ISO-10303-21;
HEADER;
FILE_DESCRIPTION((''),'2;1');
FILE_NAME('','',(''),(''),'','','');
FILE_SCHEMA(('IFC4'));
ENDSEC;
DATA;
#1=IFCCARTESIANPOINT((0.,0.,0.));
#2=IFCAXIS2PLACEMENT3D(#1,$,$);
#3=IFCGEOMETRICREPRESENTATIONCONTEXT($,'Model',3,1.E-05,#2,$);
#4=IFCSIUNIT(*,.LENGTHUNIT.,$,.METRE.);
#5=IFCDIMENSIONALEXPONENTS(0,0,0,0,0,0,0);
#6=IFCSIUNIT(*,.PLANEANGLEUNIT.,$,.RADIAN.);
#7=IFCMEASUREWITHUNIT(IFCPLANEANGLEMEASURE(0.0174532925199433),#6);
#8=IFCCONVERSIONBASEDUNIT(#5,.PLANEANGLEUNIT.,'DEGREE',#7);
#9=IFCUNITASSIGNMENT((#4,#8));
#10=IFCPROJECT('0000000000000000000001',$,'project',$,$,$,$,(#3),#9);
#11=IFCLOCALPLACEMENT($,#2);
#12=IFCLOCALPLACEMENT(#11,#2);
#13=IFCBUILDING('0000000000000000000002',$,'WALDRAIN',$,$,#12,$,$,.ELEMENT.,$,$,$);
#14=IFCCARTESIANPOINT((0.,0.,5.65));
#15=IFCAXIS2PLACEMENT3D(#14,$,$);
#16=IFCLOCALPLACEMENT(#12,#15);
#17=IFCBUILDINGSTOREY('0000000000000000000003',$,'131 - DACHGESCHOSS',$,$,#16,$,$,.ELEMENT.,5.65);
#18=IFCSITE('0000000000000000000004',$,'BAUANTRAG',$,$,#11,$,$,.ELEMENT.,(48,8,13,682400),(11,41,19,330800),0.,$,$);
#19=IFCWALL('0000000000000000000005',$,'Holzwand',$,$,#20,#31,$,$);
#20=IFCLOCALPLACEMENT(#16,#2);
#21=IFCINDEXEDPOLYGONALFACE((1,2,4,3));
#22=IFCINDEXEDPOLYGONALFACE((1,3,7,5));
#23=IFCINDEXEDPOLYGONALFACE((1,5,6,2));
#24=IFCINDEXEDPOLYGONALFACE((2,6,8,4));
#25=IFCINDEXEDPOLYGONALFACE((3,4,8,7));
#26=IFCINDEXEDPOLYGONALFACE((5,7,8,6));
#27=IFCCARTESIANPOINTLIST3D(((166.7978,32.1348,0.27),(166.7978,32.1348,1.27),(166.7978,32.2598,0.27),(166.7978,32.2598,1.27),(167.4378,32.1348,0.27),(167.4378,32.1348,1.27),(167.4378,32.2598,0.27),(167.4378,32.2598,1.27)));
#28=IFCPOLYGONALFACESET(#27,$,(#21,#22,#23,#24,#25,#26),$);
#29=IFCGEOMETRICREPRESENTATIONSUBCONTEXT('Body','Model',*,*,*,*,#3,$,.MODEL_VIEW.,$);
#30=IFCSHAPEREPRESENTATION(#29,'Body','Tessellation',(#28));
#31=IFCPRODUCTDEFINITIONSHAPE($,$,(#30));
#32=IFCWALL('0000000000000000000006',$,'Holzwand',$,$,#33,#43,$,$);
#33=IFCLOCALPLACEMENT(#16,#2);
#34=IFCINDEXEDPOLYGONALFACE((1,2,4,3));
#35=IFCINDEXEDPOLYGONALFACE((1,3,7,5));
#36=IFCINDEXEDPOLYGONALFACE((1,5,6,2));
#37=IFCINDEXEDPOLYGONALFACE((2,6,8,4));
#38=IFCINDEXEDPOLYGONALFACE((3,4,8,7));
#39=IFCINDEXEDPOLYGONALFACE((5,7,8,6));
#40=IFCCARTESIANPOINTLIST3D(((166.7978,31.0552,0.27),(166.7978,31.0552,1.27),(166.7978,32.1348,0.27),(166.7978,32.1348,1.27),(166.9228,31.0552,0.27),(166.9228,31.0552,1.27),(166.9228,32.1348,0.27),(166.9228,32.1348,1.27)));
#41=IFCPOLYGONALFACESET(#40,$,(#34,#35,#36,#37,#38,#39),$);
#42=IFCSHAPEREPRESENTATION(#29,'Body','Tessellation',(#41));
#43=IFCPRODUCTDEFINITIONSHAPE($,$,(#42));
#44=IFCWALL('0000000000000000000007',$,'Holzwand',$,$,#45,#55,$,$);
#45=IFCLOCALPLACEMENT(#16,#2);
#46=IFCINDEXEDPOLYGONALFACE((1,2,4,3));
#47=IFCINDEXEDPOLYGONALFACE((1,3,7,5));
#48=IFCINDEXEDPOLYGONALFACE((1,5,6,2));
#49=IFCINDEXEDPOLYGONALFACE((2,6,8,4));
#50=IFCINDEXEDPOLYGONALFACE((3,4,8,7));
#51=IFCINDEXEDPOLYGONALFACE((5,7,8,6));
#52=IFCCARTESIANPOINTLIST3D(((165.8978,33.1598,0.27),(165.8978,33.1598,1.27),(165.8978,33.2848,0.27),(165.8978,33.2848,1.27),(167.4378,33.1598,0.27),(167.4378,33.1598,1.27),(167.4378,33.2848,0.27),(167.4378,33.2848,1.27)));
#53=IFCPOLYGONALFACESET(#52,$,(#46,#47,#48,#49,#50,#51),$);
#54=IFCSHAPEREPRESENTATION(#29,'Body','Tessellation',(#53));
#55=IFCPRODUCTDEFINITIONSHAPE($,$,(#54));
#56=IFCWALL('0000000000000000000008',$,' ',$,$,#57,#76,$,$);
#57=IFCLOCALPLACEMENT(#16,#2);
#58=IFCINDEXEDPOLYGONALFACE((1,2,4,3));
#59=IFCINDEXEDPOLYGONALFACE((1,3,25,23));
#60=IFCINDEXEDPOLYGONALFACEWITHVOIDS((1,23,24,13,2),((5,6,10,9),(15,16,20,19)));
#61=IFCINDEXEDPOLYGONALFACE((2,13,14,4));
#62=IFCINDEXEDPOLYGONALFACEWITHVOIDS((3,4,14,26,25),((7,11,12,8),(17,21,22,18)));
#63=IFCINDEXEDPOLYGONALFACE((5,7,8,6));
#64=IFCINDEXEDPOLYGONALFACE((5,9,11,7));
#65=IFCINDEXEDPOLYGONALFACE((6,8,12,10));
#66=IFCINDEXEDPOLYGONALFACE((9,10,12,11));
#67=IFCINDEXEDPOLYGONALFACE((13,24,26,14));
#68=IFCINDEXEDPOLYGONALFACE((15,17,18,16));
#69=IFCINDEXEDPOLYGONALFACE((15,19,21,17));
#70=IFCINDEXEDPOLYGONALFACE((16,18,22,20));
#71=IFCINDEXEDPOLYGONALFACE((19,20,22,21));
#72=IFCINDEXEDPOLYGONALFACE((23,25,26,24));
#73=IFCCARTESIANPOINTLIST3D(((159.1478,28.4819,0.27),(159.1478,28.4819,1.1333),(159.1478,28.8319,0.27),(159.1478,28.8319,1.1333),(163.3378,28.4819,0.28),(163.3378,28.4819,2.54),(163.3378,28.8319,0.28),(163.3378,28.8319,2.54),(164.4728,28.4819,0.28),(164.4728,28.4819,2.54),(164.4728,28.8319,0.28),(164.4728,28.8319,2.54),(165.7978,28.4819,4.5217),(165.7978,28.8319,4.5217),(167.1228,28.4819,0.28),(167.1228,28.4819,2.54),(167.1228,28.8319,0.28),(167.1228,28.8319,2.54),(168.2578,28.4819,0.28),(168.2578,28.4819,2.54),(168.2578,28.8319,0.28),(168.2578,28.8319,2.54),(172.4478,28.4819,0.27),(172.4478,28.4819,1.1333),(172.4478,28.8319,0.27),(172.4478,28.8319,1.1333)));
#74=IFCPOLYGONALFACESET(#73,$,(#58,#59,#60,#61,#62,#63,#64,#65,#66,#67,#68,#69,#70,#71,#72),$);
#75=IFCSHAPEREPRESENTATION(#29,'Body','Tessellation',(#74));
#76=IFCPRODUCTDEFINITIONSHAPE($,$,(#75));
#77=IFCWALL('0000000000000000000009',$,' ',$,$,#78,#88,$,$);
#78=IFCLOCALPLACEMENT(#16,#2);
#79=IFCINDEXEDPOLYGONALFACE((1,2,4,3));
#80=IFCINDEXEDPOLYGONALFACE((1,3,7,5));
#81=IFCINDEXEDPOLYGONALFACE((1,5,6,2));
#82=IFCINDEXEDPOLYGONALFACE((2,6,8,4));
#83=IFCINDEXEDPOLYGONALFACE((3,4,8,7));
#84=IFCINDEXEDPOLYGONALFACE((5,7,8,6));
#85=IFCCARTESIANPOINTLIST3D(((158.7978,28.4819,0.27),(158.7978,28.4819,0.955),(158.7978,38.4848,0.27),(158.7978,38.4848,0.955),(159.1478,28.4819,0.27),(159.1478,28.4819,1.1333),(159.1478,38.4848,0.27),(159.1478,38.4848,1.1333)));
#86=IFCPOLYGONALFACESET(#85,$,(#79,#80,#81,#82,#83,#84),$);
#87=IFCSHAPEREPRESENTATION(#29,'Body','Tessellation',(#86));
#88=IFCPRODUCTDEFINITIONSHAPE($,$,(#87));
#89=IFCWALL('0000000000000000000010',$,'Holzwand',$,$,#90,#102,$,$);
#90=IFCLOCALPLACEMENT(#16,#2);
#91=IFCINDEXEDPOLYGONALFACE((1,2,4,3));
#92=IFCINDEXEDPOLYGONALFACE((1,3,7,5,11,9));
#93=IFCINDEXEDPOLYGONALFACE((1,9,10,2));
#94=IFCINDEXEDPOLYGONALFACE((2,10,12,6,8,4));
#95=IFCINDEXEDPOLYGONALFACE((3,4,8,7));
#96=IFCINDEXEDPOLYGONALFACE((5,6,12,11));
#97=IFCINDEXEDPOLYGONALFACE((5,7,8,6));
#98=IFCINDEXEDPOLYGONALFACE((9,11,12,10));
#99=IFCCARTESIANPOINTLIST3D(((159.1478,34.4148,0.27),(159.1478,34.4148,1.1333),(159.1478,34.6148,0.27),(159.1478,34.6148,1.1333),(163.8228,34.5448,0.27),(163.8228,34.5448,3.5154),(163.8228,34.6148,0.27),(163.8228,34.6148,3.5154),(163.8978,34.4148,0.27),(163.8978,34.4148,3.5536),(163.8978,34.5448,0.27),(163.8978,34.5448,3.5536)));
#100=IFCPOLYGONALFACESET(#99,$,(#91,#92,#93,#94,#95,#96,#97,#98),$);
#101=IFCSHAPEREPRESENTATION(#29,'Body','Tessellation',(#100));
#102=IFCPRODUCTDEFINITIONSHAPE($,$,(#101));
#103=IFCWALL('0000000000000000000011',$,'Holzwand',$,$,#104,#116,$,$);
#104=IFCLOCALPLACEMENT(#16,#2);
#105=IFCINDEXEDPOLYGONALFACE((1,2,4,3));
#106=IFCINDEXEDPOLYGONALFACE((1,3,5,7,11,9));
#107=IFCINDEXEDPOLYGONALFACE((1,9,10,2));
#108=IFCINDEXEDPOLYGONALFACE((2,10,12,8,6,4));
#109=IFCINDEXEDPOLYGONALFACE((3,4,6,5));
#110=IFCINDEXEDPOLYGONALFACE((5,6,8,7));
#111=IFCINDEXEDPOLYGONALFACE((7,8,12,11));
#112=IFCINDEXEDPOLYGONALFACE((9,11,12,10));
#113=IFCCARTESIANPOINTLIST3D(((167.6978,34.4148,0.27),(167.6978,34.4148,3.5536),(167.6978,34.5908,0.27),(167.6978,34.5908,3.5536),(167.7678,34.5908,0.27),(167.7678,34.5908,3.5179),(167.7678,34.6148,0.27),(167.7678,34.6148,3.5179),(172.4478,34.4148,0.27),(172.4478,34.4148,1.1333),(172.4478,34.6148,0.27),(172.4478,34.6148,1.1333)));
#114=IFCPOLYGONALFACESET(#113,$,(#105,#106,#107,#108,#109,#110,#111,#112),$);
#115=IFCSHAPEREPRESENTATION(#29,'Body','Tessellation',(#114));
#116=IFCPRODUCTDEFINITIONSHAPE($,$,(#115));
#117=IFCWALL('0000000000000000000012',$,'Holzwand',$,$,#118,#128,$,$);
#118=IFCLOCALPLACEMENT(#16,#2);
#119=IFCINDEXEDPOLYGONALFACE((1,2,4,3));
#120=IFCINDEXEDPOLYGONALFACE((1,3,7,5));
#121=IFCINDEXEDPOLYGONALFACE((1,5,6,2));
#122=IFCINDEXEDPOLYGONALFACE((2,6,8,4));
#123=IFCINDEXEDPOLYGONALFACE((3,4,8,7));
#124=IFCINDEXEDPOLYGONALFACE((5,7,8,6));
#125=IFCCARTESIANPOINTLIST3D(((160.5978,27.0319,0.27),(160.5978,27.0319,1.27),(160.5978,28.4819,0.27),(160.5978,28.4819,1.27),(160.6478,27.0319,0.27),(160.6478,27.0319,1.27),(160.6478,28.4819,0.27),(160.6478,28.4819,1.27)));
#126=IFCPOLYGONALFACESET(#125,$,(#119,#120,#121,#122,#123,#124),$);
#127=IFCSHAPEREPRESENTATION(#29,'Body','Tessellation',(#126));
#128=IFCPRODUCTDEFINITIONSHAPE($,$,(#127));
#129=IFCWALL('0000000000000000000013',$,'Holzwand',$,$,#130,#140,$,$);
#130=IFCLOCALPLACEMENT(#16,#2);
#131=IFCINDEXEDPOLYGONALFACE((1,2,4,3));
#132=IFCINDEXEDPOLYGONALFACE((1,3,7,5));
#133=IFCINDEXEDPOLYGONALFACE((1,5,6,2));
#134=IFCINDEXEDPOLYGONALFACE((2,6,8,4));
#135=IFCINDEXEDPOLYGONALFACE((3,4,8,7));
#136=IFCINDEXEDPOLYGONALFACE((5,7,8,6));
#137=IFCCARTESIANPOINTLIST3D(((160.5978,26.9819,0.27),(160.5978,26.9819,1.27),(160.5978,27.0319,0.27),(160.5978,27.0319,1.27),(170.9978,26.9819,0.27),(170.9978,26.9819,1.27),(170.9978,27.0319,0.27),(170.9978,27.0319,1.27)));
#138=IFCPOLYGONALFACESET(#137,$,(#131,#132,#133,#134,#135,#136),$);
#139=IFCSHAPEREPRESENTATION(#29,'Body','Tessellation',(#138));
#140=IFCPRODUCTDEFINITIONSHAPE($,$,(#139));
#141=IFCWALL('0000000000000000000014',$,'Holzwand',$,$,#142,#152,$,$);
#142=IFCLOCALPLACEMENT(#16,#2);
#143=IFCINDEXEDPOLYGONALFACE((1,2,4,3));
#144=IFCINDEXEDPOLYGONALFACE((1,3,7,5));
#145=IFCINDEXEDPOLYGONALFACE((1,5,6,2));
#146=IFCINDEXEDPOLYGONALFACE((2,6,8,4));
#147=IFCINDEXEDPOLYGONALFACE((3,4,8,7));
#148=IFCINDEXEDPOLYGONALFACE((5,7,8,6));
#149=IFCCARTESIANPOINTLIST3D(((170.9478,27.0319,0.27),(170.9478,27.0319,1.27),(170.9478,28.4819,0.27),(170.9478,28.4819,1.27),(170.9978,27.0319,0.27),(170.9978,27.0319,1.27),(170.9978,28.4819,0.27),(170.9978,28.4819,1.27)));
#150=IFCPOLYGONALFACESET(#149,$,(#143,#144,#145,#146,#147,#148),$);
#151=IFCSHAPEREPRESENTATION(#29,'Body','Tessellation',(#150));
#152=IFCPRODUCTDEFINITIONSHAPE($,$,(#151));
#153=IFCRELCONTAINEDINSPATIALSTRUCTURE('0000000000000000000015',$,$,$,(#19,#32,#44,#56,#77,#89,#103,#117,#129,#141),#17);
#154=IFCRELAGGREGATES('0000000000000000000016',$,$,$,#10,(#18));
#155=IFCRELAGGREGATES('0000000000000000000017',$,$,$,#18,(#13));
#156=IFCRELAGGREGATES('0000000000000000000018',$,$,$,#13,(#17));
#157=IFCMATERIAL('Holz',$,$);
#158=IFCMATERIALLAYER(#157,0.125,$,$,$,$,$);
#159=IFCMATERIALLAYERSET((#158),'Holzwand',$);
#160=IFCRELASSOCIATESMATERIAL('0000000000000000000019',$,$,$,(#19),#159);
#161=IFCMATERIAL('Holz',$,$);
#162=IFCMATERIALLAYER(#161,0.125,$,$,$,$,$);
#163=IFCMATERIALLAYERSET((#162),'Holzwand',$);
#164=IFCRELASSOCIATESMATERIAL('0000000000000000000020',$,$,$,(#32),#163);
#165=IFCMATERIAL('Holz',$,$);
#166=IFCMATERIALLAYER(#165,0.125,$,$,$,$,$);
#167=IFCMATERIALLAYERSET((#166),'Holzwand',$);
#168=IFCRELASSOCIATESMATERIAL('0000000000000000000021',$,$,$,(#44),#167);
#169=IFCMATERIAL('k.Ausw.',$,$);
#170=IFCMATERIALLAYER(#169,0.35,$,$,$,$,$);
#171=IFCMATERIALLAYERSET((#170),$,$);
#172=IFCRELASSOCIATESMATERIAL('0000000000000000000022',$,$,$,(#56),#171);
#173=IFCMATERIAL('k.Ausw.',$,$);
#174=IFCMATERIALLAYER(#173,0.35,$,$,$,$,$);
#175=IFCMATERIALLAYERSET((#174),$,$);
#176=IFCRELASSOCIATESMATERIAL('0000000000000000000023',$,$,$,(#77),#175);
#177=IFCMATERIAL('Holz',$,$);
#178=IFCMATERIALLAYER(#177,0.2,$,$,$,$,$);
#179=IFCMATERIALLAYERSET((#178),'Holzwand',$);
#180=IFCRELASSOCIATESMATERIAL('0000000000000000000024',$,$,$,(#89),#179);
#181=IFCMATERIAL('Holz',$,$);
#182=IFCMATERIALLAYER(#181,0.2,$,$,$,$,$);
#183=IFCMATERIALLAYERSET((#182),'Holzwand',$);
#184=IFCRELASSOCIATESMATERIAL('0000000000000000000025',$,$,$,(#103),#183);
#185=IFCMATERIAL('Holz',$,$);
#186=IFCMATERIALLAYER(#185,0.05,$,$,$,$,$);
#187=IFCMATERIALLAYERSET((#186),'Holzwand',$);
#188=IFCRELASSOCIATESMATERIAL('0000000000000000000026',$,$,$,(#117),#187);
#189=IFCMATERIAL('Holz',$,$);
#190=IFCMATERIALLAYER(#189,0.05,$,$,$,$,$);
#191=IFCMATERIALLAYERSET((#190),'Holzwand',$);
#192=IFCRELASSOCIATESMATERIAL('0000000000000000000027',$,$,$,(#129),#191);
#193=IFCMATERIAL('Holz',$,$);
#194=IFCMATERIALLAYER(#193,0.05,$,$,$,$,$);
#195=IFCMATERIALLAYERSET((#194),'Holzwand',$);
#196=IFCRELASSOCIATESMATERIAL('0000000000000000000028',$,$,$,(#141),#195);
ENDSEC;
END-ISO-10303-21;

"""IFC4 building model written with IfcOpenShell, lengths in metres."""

from ifc_helpers import new_model, entity, si_unit, converted_unit, frame, frame_2d, origin, origin_with_axes, place, context, subcontext, project, spatial, polyline, rectangle, outline, extrude, clip, halfspace, bounded_halfspace, material, layer, layer_set, layer_usage, element, save


model = new_model("IFC4")

# Units and contexts
model_context = context("Model", 3, precision=1e-05, world=origin())
body_context = subcontext(model_context, "Body", "Model", "MODEL_VIEW")
ifc_project = project(units=[si_unit("LENGTHUNIT", "METRE"), converted_unit("PLANEANGLEUNIT", "DEGREE", entity("IfcPlaneAngleMeasure", 0.0174532925199433), si_unit("PLANEANGLEUNIT", "RADIAN"), dimensions=[0, 0, 0, 0, 0, 0, 0])], contexts=[model_context])

# Site, building, storey
site_placement = place(None, origin())
site = spatial("IfcSite", under=ifc_project, at=site_placement, Name="BAUANTRAG", CompositionType="ELEMENT", RefLatitude=(48, 8, 13, 682400), RefLongitude=(11, 41, 19, 330800), RefElevation=0.0)
building_placement = place(site_placement, origin())
building = spatial("IfcBuilding", under=site, at=building_placement, Name="WALDRAIN", CompositionType="ELEMENT")
storey_placement = place(building_placement, frame((0.0, 0.0, 5.65)))
storey = spatial("IfcBuildingStorey", under=building, at=storey_placement, Name="131 - DACHGESCHOSS", CompositionType="ELEMENT", Elevation=5.65)

# Walls
ifc_material_1 = material(Name="Holz")
ifc_layer_1 = layer(ifc_material_1, 0.125)
ifc_layer_set_1 = layer_set([ifc_layer_1], Name="Holzwand")
ifc_layer_usage_1 = layer_usage(ifc_layer_set_1, "AXIS2", "POSITIVE", 0.0)
wall_1_placement = place(storey_placement, frame((167.4378, 32.2598, 0.27), z_axis=(0.0, 0.0, 1.0), x_axis=(-1.0, 0.0, 0.0)))
element("IfcWall", 1, at=wall_1_placement, inside=storey, material=ifc_layer_usage_1, Name="Holzwand", context=body_context, shape_type="SweptSolid", body=[
    extrude(rectangle(XDim=0.64, YDim=0.125, at=frame_2d((0.32, 0.0625), x_axis=(1.0, 0.0))), origin_with_axes(), (0.0, 0.0, 1.0), 1.0),
])
ifc_material_2 = material(Name="Holz")
ifc_layer_2 = layer(ifc_material_2, 0.125)
ifc_layer_set_2 = layer_set([ifc_layer_2], Name="Holzwand")
ifc_layer_usage_2 = layer_usage(ifc_layer_set_2, "AXIS2", "POSITIVE", 0.0)
wall_2_placement = place(storey_placement, frame((166.7978, 32.1348, 0.27), z_axis=(0.0, 0.0, 1.0), x_axis=(0.0, -1.0, 0.0)))
element("IfcWall", 2, at=wall_2_placement, inside=storey, material=ifc_layer_usage_2, Name="Holzwand", context=body_context, shape_type="SweptSolid", body=[
    extrude(rectangle(XDim=1.0796, YDim=0.125, at=frame_2d((0.5398, 0.0625), x_axis=(1.0, 0.0))), origin_with_axes(), (0.0, 0.0, 1.0), 1.0),
])
ifc_material_3 = material(Name="Holz")
ifc_layer_3 = layer(ifc_material_3, 0.125)
ifc_layer_set_3 = layer_set([ifc_layer_3], Name="Holzwand")
ifc_layer_usage_3 = layer_usage(ifc_layer_set_3, "AXIS2", "POSITIVE", 0.0)
wall_3_placement = place(storey_placement, frame((165.8978, 33.1598, 0.27)))
element("IfcWall", 3, at=wall_3_placement, inside=storey, material=ifc_layer_usage_3, Name="Holzwand", context=body_context, shape_type="SweptSolid", body=[
    extrude(rectangle(XDim=1.54, YDim=0.125, at=frame_2d((0.77, 0.0625), x_axis=(1.0, 0.0))), origin_with_axes(), (0.0, 0.0, 1.0), 1.0),
])

# Wall, openings
ifc_material_4 = material(Name="k.Ausw.")
ifc_layer_4 = layer(ifc_material_4, 0.35)
ifc_layer_set_4 = layer_set([ifc_layer_4])
ifc_layer_usage_4 = layer_usage(ifc_layer_set_4, "AXIS2", "POSITIVE", 0.0)
wall_4_placement = place(storey_placement, frame((159.1478, 28.4819, 0.27)))
wall_4 = element("IfcWall", 4, at=wall_4_placement, inside=storey, material=ifc_layer_usage_4, Name=" ", context=body_context, shape_type="Clipping", body=[
    clip(clip(extrude(rectangle(XDim=13.3, YDim=0.35, at=frame_2d((6.65, 0.175), x_axis=(1.0, 0.0))), origin_with_axes(), (0.0, 0.0, 1.0), 4.2517), bounded_halfspace(frame((3.325, 0.175, 2.5575), z_axis=(0.45399, 0.0, -0.891007), x_axis=(0.0, -1.0, 0.0)), True, origin_with_axes(), polyline([(0.0, 0.35), (0.0, 0.0), (6.65, 0.0), (6.65, 0.35), (0.0, 0.35)]))), bounded_halfspace(frame((9.975, 0.175, 2.5575), z_axis=(-0.45399, 0.0, -0.891007), x_axis=(0.891007, 0.0, -0.45399)), True, origin_with_axes(), polyline([(6.65, 0.0), (13.3, 0.0), (13.3, 0.35), (6.65, 0.35), (6.65, 0.0)]))),
])
opening_1_placement = place(wall_4_placement, frame((9.11, 0.35, 0.01), z_axis=(0.0, -1.0, 0.0), x_axis=(0.0, 0.0, 1.0)))
element("IfcOpeningElement", 5, at=opening_1_placement, cuts=wall_4, ObjectType="Opening", context=body_context, shape_type="SweptSolid", body=[
    extrude(outline(polyline([(0.0, 1.135), (2.26, 1.135), (2.26, 0.0), (0.0, 0.0), (0.0, 1.135)])), origin_with_axes(), (0.0, 0.0, 1.0), 0.35),
])
opening_2_placement = place(wall_4_placement, frame((5.325, 0.35, 0.01), z_axis=(0.0, -1.0, 0.0), x_axis=(0.0, 0.0, 1.0)))
element("IfcOpeningElement", 6, at=opening_2_placement, cuts=wall_4, ObjectType="Opening", context=body_context, shape_type="SweptSolid", body=[
    extrude(outline(polyline([(0.0, 1.135), (2.26, 1.135), (2.26, 0.0), (0.0, 0.0), (0.0, 1.135)])), origin_with_axes(), (0.0, 0.0, 1.0), 0.35),
])

# Walls
ifc_material_5 = material(Name="k.Ausw.")
ifc_layer_5 = layer(ifc_material_5, 0.35)
ifc_layer_set_5 = layer_set([ifc_layer_5])
ifc_layer_usage_5 = layer_usage(ifc_layer_set_5, "AXIS2", "POSITIVE", 0.0)
wall_5_placement = place(storey_placement, frame((158.7978, 38.4848, 0.27), z_axis=(0.0, 0.0, 1.0), x_axis=(0.0, -1.0, 0.0)))
element("IfcWall", 7, at=wall_5_placement, inside=storey, material=ifc_layer_usage_5, Name=" ", context=body_context, shape_type="Clipping", body=[
    clip(extrude(rectangle(XDim=10.0029, YDim=0.35, at=frame_2d((5.0014, 0.175), x_axis=(1.0, 0.0))), origin_with_axes(), (0.0, 0.0, 1.0), 0.8633), halfspace(frame((5.0014, 0.175, 0.7742), z_axis=(0.0, 0.45399, -0.891007), x_axis=(0.0, -0.891007, -0.45399)), True)),
])
ifc_material_6 = material(Name="Holz")
ifc_layer_6 = layer(ifc_material_6, 0.2)
ifc_layer_set_6 = layer_set([ifc_layer_6], Name="Holzwand")
ifc_layer_usage_6 = layer_usage(ifc_layer_set_6, "AXIS2", "POSITIVE", 0.0)
wall_6_placement = place(storey_placement, frame((159.1478, 34.4148, 0.27)))
element("IfcWall", 8, at=wall_6_placement, inside=storey, material=ifc_layer_usage_6, Name="Holzwand", context=body_context, shape_type="Clipping", body=[
    clip(extrude(outline(polyline([(0.0, 0.0), (4.75, 0.0), (4.75, 0.13), (4.675, 0.13), (4.675, 0.2), (0.0, 0.2), (0.0, 0.0)])), origin_with_axes(), (0.0, 0.0, 1.0), 3.2836), halfspace(frame((3.1417, 0.11, 2.4641), z_axis=(0.45399, 0.0, -0.891007), x_axis=(0.891007, 0.0, 0.45399)), True)),
])
ifc_material_7 = material(Name="Holz")
ifc_layer_7 = layer(ifc_material_7, 0.2)
ifc_layer_set_7 = layer_set([ifc_layer_7], Name="Holzwand")
ifc_layer_usage_7 = layer_usage(ifc_layer_set_7, "AXIS2", "POSITIVE", 0.0)
wall_7_placement = place(storey_placement, frame((167.6978, 34.4148, 0.27)))
element("IfcWall", 9, at=wall_7_placement, inside=storey, material=ifc_layer_usage_7, Name="Holzwand", context=body_context, shape_type="Clipping", body=[
    clip(extrude(outline(polyline([(0.0, 0.0), (4.75, 0.0), (4.75, 0.2), (0.07, 0.2), (0.07, 0.176), (0.0, 0.176), (0.0, 0.0)])), origin_with_axes(), (0.0, 0.0, 1.0), 3.2836), halfspace(frame((1.6067, 0.1253, 2.4649), z_axis=(-0.45399, 0.0, -0.891007), x_axis=(0.891007, 0.0, -0.45399)), True)),
])
ifc_material_8 = material(Name="Holz")
ifc_layer_8 = layer(ifc_material_8, 0.05)
ifc_layer_set_8 = layer_set([ifc_layer_8], Name="Holzwand")
ifc_layer_usage_8 = layer_usage(ifc_layer_set_8, "AXIS2", "POSITIVE", 0.0)
wall_8_placement = place(storey_placement, frame((160.5978, 28.4819, 0.27), z_axis=(0.0, 0.0, 1.0), x_axis=(0.0, -1.0, 0.0)))
element("IfcWall", 10, at=wall_8_placement, inside=storey, material=ifc_layer_usage_8, Name="Holzwand", context=body_context, shape_type="SweptSolid", body=[
    extrude(rectangle(XDim=1.45, YDim=0.05, at=frame_2d((0.725, 0.025), x_axis=(1.0, 0.0))), origin_with_axes(), (0.0, 0.0, 1.0), 1.0),
])
ifc_material_9 = material(Name="Holz")
ifc_layer_9 = layer(ifc_material_9, 0.05)
ifc_layer_set_9 = layer_set([ifc_layer_9], Name="Holzwand")
ifc_layer_usage_9 = layer_usage(ifc_layer_set_9, "AXIS2", "POSITIVE", 0.0)
wall_9_placement = place(storey_placement, frame((160.5978, 26.9819, 0.27)))
element("IfcWall", 11, at=wall_9_placement, inside=storey, material=ifc_layer_usage_9, Name="Holzwand", context=body_context, shape_type="SweptSolid", body=[
    extrude(rectangle(XDim=10.4, YDim=0.05, at=frame_2d((5.2, 0.025), x_axis=(1.0, 0.0))), origin_with_axes(), (0.0, 0.0, 1.0), 1.0),
])
ifc_material_10 = material(Name="Holz")
ifc_layer_10 = layer(ifc_material_10, 0.05)
ifc_layer_set_10 = layer_set([ifc_layer_10], Name="Holzwand")
ifc_layer_usage_10 = layer_usage(ifc_layer_set_10, "AXIS2", "POSITIVE", 0.0)
wall_10_placement = place(storey_placement, frame((170.9978, 27.0319, 0.27), z_axis=(0.0, 0.0, 1.0), x_axis=(0.0, 1.0, 0.0)))
element("IfcWall", 12, at=wall_10_placement, inside=storey, material=ifc_layer_usage_10, Name="Holzwand", context=body_context, shape_type="SweptSolid", body=[
    extrude(rectangle(XDim=1.45, YDim=0.05, at=frame_2d((0.725, 0.025), x_axis=(1.0, 0.0))), origin_with_axes(), (0.0, 0.0, 1.0), 1.0),
])

save(model, "model.ifc")
